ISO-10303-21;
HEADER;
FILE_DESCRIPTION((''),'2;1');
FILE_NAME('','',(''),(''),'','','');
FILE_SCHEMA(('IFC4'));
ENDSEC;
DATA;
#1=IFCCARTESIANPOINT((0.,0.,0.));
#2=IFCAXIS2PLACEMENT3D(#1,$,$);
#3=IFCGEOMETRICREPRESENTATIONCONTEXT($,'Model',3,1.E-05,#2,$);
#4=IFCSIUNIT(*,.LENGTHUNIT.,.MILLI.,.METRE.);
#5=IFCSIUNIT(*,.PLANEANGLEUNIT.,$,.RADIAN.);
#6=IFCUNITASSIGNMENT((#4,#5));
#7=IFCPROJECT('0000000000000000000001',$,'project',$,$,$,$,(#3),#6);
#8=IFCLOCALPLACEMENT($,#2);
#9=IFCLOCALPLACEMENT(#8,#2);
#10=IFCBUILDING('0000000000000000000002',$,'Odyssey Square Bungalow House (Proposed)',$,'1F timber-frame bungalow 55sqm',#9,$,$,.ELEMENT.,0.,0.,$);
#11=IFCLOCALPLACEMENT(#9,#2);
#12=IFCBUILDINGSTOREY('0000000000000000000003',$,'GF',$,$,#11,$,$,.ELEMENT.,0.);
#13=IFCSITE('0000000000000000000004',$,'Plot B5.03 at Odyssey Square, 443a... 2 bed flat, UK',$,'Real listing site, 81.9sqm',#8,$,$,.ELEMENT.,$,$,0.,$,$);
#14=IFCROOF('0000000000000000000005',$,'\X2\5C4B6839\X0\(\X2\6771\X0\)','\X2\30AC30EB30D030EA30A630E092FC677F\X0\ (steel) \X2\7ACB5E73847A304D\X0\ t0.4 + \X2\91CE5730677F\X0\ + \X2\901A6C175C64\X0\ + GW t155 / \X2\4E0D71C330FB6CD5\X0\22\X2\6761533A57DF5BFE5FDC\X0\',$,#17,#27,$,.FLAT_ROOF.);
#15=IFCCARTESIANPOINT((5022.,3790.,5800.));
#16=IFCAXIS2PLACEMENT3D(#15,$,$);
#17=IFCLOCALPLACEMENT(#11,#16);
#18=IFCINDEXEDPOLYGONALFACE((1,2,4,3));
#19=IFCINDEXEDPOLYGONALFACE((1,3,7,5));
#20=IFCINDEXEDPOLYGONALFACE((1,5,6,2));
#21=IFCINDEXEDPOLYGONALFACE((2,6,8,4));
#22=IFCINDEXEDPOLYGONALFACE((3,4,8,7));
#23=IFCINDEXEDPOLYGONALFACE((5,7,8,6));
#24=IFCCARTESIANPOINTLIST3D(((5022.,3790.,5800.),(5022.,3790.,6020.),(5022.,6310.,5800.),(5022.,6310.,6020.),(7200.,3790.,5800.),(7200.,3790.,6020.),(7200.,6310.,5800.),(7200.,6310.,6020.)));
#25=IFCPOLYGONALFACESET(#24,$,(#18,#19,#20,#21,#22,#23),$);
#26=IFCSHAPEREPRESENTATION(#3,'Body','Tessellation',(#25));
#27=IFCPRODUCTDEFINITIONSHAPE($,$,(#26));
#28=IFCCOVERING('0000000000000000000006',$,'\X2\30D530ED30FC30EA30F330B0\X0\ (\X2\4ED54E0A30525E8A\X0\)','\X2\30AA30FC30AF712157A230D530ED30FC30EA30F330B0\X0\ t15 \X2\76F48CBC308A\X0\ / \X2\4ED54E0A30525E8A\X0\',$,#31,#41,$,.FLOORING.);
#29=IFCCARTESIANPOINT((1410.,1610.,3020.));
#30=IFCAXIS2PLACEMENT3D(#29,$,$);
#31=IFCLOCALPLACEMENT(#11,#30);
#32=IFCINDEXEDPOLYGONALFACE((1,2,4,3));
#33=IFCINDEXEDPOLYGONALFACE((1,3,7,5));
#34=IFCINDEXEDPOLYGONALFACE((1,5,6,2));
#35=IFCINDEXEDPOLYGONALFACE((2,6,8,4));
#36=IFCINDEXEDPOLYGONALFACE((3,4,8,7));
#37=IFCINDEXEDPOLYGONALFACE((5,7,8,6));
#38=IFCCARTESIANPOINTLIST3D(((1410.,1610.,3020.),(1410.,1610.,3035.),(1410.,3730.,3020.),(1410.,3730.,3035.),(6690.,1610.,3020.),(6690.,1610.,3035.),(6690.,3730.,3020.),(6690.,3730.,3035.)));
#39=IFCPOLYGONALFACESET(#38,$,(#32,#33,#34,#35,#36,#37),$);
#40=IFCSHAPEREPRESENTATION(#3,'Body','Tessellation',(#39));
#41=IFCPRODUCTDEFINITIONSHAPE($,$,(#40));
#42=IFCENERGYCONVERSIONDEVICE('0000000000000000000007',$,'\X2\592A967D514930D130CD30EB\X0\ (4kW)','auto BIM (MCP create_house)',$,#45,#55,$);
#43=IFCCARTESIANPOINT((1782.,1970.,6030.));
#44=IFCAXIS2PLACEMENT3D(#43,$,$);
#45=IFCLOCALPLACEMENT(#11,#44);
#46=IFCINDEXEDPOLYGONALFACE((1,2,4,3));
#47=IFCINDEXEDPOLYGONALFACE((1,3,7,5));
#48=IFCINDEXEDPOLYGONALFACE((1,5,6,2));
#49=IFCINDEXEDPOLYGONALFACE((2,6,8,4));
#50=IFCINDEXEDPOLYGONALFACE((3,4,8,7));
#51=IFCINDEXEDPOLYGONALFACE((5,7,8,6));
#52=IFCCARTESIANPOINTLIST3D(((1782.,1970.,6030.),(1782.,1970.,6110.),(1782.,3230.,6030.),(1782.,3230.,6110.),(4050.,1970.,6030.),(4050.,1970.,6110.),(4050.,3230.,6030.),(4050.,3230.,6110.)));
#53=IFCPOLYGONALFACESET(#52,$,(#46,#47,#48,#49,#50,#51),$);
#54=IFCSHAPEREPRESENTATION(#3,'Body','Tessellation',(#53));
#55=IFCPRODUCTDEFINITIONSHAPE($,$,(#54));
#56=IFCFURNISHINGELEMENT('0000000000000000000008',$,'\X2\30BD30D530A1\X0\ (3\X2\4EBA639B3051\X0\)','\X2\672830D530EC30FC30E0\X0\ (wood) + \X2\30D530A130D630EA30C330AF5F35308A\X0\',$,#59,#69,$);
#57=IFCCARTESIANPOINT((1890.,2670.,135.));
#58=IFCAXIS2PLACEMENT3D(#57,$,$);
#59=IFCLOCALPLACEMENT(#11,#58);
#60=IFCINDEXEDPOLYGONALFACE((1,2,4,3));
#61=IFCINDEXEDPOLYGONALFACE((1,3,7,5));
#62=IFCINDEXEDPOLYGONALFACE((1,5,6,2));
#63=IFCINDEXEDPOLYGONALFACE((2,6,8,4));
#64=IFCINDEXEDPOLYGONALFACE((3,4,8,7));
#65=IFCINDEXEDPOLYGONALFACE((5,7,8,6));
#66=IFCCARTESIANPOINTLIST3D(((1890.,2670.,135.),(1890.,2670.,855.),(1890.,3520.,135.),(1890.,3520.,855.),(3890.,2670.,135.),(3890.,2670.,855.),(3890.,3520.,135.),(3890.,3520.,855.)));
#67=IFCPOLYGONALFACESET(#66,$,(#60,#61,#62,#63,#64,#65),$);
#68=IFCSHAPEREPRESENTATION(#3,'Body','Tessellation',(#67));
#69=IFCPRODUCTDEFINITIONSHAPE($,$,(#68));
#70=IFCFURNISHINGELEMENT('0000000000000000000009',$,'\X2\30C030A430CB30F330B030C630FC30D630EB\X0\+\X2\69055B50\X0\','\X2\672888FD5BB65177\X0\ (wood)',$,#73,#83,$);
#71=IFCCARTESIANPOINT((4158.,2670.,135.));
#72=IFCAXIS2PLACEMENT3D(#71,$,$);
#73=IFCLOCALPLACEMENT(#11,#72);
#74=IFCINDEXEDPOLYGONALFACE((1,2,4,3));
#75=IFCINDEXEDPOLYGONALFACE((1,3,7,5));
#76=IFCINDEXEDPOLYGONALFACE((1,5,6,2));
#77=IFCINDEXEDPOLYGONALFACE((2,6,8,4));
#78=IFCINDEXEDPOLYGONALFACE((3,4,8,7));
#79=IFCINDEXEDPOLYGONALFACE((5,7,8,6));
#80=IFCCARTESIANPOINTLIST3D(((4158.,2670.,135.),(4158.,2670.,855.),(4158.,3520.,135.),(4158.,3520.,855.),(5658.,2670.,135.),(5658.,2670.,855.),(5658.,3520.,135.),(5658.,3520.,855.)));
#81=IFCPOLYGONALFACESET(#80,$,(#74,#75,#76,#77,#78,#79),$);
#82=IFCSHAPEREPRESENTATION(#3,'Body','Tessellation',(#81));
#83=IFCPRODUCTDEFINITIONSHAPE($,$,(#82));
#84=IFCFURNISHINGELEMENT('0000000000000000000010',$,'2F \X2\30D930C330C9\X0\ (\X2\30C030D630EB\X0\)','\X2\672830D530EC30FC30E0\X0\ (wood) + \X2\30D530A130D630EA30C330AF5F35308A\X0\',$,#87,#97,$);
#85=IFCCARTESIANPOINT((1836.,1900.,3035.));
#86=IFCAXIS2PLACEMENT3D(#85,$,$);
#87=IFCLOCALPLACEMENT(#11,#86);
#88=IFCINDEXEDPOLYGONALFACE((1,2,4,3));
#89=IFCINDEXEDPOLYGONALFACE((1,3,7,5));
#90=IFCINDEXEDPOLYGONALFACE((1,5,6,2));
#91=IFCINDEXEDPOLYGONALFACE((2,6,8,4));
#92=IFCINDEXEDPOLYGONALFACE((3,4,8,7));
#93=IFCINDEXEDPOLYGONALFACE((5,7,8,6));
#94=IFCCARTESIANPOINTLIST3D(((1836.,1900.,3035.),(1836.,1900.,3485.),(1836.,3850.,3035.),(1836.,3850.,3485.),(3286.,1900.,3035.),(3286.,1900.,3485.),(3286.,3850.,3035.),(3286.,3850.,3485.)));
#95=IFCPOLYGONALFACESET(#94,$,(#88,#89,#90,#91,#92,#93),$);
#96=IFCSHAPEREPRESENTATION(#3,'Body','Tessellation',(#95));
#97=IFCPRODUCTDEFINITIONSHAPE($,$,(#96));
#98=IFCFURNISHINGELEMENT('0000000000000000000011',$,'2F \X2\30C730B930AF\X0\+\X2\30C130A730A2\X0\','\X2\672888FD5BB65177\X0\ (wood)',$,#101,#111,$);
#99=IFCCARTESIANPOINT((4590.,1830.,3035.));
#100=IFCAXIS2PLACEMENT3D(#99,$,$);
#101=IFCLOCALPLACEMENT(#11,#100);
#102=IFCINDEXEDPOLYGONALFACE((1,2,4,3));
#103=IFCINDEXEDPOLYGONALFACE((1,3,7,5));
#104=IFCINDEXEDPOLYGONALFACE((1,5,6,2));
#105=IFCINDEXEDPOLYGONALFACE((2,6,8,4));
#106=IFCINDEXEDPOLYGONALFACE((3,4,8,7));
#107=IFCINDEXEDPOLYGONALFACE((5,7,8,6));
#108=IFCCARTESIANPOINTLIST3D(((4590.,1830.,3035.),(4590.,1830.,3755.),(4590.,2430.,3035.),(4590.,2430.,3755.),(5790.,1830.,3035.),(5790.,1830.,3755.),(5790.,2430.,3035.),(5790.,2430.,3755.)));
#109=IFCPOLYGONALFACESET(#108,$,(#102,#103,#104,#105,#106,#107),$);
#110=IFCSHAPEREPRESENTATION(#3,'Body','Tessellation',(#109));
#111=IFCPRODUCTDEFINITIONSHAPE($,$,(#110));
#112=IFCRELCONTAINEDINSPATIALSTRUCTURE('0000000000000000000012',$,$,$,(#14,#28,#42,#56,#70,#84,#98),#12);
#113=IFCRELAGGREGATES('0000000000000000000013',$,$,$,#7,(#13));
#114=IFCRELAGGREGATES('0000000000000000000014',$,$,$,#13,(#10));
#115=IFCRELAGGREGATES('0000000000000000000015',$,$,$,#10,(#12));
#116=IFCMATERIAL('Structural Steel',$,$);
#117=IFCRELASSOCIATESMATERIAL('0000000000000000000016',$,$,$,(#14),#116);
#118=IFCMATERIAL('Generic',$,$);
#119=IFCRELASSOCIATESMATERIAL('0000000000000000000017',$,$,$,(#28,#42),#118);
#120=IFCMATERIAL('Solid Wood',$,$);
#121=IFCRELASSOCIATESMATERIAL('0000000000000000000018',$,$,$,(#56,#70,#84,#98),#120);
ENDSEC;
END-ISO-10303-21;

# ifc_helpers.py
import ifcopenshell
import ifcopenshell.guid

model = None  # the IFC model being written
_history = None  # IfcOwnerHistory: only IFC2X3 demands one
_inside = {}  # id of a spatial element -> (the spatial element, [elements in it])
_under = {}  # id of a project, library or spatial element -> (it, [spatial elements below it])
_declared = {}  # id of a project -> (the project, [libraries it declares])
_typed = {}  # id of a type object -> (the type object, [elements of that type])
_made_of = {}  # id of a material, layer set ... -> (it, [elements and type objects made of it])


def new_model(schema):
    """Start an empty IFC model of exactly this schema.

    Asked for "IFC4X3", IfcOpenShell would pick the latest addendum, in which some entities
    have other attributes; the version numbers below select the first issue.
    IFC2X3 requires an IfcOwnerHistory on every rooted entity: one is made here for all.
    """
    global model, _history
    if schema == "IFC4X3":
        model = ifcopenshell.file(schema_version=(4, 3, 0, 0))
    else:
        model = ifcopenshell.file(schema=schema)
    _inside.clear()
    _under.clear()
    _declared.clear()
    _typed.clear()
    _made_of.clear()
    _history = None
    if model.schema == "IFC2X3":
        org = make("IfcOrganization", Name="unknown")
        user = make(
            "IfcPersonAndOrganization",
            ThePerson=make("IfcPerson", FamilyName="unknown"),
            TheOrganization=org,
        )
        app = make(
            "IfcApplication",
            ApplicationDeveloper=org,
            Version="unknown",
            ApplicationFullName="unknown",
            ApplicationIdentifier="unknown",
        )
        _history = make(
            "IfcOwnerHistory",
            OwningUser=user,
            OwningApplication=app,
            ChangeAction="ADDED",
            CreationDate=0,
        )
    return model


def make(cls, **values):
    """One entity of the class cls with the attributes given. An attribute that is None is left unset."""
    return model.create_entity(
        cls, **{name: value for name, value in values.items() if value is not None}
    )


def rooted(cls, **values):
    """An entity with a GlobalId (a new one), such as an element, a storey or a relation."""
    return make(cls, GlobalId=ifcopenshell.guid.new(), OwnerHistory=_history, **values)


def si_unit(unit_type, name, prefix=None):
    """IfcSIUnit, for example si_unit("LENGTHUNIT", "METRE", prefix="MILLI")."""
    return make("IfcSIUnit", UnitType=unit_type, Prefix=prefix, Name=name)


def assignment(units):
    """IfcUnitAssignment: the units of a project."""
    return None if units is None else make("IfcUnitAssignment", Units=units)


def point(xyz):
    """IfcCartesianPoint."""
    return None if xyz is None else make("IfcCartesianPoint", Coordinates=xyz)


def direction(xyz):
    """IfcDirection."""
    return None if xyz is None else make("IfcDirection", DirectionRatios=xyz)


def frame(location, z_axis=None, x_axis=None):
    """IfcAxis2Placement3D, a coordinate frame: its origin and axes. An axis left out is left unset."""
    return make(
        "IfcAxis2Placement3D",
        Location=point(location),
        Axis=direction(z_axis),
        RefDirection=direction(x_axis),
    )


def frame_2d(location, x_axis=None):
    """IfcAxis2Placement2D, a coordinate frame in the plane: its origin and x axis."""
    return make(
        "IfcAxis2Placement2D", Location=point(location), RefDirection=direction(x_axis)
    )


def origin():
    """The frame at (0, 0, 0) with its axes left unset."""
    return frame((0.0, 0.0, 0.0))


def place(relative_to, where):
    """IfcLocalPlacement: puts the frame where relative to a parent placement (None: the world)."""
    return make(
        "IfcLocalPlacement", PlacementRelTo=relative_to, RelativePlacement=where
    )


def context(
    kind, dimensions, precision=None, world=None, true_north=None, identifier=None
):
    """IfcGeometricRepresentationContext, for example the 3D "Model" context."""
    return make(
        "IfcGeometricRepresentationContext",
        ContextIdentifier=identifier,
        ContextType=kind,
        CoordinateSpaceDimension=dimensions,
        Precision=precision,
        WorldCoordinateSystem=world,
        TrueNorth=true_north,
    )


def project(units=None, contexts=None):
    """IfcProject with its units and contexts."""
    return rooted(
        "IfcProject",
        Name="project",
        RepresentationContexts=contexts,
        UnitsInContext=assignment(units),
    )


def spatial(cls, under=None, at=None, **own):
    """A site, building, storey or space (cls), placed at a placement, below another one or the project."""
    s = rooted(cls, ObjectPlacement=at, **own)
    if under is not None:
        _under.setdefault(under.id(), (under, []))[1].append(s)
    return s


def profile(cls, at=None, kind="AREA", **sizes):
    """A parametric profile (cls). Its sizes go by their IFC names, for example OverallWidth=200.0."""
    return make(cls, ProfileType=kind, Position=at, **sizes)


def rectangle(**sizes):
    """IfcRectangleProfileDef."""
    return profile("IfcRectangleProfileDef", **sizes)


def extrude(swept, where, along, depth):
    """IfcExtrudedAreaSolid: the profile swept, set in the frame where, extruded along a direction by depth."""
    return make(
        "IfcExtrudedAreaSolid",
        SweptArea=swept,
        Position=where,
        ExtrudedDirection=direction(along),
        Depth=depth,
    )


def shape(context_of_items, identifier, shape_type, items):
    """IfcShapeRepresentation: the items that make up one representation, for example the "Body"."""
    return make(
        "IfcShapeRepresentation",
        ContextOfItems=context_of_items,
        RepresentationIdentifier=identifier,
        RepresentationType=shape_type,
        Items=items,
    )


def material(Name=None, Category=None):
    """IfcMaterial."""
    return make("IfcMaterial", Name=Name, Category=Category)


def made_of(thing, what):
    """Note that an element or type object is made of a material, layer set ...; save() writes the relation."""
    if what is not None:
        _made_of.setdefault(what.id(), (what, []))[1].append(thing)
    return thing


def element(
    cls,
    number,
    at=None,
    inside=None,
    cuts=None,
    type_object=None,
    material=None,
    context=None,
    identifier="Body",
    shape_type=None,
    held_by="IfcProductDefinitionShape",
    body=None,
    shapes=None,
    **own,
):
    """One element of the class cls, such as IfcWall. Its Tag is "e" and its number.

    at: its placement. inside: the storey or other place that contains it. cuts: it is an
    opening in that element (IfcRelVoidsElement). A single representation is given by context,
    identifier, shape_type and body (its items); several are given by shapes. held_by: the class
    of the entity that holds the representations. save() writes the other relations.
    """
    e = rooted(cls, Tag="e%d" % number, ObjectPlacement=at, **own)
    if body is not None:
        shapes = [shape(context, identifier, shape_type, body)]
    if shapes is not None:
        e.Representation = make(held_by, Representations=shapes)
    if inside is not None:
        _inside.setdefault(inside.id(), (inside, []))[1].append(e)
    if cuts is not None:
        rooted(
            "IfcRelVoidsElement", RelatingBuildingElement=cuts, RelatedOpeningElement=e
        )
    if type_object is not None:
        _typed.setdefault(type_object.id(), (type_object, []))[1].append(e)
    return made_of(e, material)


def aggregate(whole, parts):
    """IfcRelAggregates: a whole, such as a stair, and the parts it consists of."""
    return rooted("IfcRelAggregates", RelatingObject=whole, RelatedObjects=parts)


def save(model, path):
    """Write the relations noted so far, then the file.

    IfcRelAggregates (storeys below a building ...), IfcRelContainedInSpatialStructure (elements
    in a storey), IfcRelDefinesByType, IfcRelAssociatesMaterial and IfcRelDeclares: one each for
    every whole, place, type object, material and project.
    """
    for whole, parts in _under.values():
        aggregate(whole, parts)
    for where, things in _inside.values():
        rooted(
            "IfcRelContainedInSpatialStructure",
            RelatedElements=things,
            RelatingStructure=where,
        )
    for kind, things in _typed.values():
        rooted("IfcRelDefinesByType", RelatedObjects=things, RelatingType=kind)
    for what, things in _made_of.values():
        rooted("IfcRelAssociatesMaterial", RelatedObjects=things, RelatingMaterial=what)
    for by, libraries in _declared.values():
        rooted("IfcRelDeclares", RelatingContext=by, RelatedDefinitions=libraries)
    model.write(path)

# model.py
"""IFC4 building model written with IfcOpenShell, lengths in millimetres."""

from ifc_helpers import new_model, si_unit, frame, frame_2d, origin, place, context, project, spatial, rectangle, extrude, material, element, save


model = new_model("IFC4")

# Units and contexts
model_context = context("Model", 3, precision=1e-05, world=origin())
ifc_project = project(units=[si_unit("LENGTHUNIT", "METRE", prefix="MILLI"), si_unit("PLANEANGLEUNIT", "RADIAN")], contexts=[model_context])

# Site, building, storey
site_placement = place(None, origin())
site = spatial("IfcSite", under=ifc_project, at=site_placement, Name="Plot B5.03 at Odyssey Square, 443a... 2 bed flat, UK", ObjectType="Real listing site, 81.9sqm", CompositionType="ELEMENT", RefElevation=0.0)
building_placement = place(site_placement, origin())
building = spatial("IfcBuilding", under=site, at=building_placement, Name="Odyssey Square Bungalow House (Proposed)", ObjectType="1F timber-frame bungalow 55sqm", CompositionType="ELEMENT", ElevationOfRefHeight=0.0, ElevationOfTerrain=0.0)
storey_placement = place(building_placement, origin())
storey = spatial("IfcBuildingStorey", under=building, at=storey_placement, Name="GF", CompositionType="ELEMENT", Elevation=0.0)

# Shared definitions
ifc_material_1 = material(Name="Solid Wood")

# Roof
ifc_material_2 = material(Name="Structural Steel")
roof_1_placement = place(storey_placement, frame((5022.0, 3790.0, 5800.0)))
element("IfcRoof", 1, at=roof_1_placement, inside=storey, material=ifc_material_2, Name="屋根(東)", Description="ガルバリウム鋼板 (steel) 立平葺き t0.4 + 野地板 + 通気層 + GW t155 / 不燃・法22条区域対応", PredefinedType="FLAT_ROOF", context=model_context, shape_type="SweptSolid", body=[
    extrude(rectangle(XDim=2178.0, YDim=2520.0, at=frame_2d((1089.0, 1260.0))), frame((5022.0, 3790.0, 5800.0)), (0.0, 0.0, 1.0), 220.0),
])

# Covering
ifc_material_3 = material(Name="Generic")
covering_placement = place(storey_placement, frame((1410.0, 1610.0, 3020.0)))
element("IfcCovering", 2, at=covering_placement, inside=storey, material=ifc_material_3, Name="フローリング (仕上げ床)", Description="オーク無垢フローリング t15 直貼り / 仕上げ床", PredefinedType="FLOORING", context=model_context, shape_type="SweptSolid", body=[
    extrude(rectangle(XDim=5280.0, YDim=2120.0, at=frame_2d((2640.0, 1060.0))), frame((1410.0, 1610.0, 3020.0)), (0.0, 0.0, 1.0), 15.0),
])

# Energy conversion device
energy_conversion_device_placement = place(storey_placement, frame((1782.0, 1970.0, 6030.0)))
element("IfcEnergyConversionDevice", 3, at=energy_conversion_device_placement, inside=storey, material=ifc_material_3, Name="太陽光パネル (4kW)", Description="auto BIM (MCP create_house)", context=model_context, shape_type="SweptSolid", body=[
    extrude(rectangle(XDim=2268.0, YDim=1260.0, at=frame_2d((1134.0, 630.0))), frame((1782.0, 1970.0, 6030.0)), (0.0, 0.0, 1.0), 80.0),
])

# Furnishing elements
furnishing_1_placement = place(storey_placement, frame((1890.0, 2670.0, 135.0)))
element("IfcFurnishingElement", 4, at=furnishing_1_placement, inside=storey, material=ifc_material_1, Name="ソファ (3人掛け)", Description="木フレーム (wood) + ファブリック張り", context=model_context, shape_type="SweptSolid", body=[
    extrude(rectangle(XDim=2000.0, YDim=850.0, at=frame_2d((1000.0, 425.0))), frame((1890.0, 2670.0, 135.0)), (0.0, 0.0, 1.0), 720.0),
])
furnishing_2_placement = place(storey_placement, frame((4158.0, 2670.0, 135.0)))
element("IfcFurnishingElement", 5, at=furnishing_2_placement, inside=storey, material=ifc_material_1, Name="ダイニングテーブル+椅子", Description="木製家具 (wood)", context=model_context, shape_type="SweptSolid", body=[
    extrude(rectangle(XDim=1500.0, YDim=850.0, at=frame_2d((750.0, 425.0))), frame((4158.0, 2670.0, 135.0)), (0.0, 0.0, 1.0), 720.0),
])
furnishing_3_placement = place(storey_placement, frame((1836.0, 1900.0, 3035.0)))
element("IfcFurnishingElement", 6, at=furnishing_3_placement, inside=storey, material=ifc_material_1, Name="2F ベッド (ダブル)", Description="木フレーム (wood) + ファブリック張り", context=model_context, shape_type="SweptSolid", body=[
    extrude(rectangle(XDim=1450.0, YDim=1950.0, at=frame_2d((725.0, 975.0))), frame((1836.0, 1900.0, 3035.0)), (0.0, 0.0, 1.0), 450.0),
])
furnishing_4_placement = place(storey_placement, frame((4590.0, 1830.0, 3035.0)))
element("IfcFurnishingElement", 7, at=furnishing_4_placement, inside=storey, material=ifc_material_1, Name="2F デスク+チェア", Description="木製家具 (wood)", context=model_context, shape_type="SweptSolid", body=[
    extrude(rectangle(XDim=1200.0, YDim=600.0, at=frame_2d((600.0, 300.0))), frame((4590.0, 1830.0, 3035.0)), (0.0, 0.0, 1.0), 720.0),
])

save(model, "model.ifc")
